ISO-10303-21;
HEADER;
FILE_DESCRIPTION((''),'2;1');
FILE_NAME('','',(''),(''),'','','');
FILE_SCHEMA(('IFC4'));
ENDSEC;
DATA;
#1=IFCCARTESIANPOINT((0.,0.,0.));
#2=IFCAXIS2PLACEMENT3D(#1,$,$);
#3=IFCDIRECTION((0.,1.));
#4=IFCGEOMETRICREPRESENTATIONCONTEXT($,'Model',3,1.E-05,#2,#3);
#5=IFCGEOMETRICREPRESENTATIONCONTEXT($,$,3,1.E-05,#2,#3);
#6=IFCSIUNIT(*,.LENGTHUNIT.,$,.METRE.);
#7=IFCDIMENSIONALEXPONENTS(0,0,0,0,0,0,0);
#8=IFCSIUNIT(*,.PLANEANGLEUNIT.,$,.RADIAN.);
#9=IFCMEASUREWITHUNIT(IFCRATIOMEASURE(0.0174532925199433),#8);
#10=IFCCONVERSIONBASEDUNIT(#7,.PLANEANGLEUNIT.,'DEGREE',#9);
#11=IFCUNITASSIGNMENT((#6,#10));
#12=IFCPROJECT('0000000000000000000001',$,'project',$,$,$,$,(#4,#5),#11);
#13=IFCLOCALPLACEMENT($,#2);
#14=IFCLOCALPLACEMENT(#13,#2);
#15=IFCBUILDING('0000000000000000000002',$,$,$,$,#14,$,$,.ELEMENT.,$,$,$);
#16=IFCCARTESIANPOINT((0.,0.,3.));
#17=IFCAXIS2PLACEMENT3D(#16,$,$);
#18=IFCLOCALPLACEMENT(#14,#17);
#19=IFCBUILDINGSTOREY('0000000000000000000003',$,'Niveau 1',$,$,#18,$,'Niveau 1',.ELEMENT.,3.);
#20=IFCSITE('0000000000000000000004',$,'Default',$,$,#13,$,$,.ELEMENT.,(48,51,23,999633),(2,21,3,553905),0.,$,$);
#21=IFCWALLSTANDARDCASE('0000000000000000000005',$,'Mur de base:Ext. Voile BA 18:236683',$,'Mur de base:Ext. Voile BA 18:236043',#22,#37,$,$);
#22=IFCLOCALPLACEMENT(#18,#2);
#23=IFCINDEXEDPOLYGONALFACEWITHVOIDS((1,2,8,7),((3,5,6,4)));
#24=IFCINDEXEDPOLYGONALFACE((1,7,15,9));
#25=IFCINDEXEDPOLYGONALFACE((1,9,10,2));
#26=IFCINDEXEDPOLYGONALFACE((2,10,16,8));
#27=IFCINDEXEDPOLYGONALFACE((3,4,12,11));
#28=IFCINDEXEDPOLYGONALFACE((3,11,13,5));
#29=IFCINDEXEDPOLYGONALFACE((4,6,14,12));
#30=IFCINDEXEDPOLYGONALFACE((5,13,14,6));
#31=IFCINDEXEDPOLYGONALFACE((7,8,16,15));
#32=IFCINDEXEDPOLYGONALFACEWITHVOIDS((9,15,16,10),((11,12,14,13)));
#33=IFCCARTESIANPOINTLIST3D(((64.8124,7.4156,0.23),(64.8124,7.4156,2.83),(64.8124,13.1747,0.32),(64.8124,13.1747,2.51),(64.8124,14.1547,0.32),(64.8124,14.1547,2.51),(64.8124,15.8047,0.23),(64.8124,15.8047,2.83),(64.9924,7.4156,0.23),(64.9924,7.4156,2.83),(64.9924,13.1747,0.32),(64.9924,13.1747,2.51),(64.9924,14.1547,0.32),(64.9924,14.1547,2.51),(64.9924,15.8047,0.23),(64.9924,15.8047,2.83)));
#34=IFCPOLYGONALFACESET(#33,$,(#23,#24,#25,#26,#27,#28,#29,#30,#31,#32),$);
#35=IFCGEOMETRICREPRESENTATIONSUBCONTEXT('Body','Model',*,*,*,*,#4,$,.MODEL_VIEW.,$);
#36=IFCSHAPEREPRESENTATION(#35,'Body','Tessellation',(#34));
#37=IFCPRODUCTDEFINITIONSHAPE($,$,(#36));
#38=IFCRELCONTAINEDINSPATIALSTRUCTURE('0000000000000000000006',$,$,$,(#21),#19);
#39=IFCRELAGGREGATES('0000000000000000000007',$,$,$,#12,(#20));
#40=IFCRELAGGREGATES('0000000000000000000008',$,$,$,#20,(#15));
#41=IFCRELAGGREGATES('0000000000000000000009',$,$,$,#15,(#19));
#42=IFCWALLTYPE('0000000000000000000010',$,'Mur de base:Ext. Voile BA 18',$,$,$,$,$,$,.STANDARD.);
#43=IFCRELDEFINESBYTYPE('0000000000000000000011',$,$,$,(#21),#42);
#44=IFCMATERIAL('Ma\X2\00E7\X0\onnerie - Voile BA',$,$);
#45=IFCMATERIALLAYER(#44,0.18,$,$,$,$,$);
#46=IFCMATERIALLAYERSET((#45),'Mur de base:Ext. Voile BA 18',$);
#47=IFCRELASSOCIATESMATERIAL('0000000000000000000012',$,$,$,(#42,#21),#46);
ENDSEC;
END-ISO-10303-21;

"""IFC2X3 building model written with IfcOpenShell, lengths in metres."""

from ifc_helpers import new_model, entity, si_unit, converted_unit, direction, frame, frame_2d, origin, place, context, subcontext, project, spatial, rectangle, extrude, material, layer, layer_set, layer_usage, type_object, element, save


model = new_model("IFC2X3")

# Units and contexts
model_context = context("Model", 3, precision=1e-05, world=origin(), true_north=direction((0.0, 1.0)))
context_of_model = context(None, 3, precision=1e-05, world=origin(), true_north=direction((0.0, 1.0)))
body_context = subcontext(model_context, "Body", "Model", "MODEL_VIEW")
ifc_project = project(units=[si_unit("LENGTHUNIT", "METRE"), converted_unit("PLANEANGLEUNIT", "DEGREE", entity("IfcRatioMeasure", 0.0174532925199433), si_unit("PLANEANGLEUNIT", "RADIAN"), dimensions=[0, 0, 0, 0, 0, 0, 0])], contexts=[model_context, context_of_model])

# Site, building, storey
site_placement = place(None, origin())
site = spatial("IfcSite", under=ifc_project, at=site_placement, Name="Default", CompositionType="ELEMENT", RefLatitude=(48, 51, 23, 999633), RefLongitude=(2, 21, 3, 553905), RefElevation=0.0)
building_placement = place(site_placement, origin())
building = spatial("IfcBuilding", under=site, at=building_placement, CompositionType="ELEMENT")
storey_placement = place(building_placement, frame((0.0, 0.0, 3.0)))
storey = spatial("IfcBuildingStorey", under=building, at=storey_placement, Name="Niveau 1", LongName="Niveau 1", CompositionType="ELEMENT", Elevation=3.0)

# Shared definitions
ifc_material = material(Name="Maçonnerie - Voile BA")

# Shared definitions
ifc_layer_1 = layer(ifc_material, 0.18)
ifc_layer_set_1 = layer_set([ifc_layer_1], Name="Mur de base:Ext. Voile BA 18")
wall_type_1 = type_object("IfcWallType", Name="Mur de base:Ext. Voile BA 18", PredefinedType="STANDARD", material=ifc_layer_set_1)

# Wall, opening
ifc_layer_usage_1 = layer_usage(ifc_layer_set_1, "AXIS2", "POSITIVE", -0.09)
wall_1_placement = place(storey_placement, frame((64.9024, 15.8047, 0.23), z_axis=(0.0, 0.0, 1.0), x_axis=(0.0, -1.0, 0.0)))
wall_1 = element("IfcWallStandardCase", 1, at=wall_1_placement, inside=storey, type_object=wall_type_1, material=ifc_layer_usage_1, Name="Mur de base:Ext. Voile BA 18:236683", ObjectType="Mur de base:Ext. Voile BA 18:236043", context=body_context, shape_type="SweptSolid", body=[
    extrude(rectangle(XDim=8.3891, YDim=0.18, at=frame_2d((4.1946, 0.0), x_axis=(-1.0, 0.0))), origin(), (0.0, 0.0, 1.0), 2.6),
])
opening_1_placement = place(wall_1_placement, origin())
element("IfcOpeningElement", 2, at=opening_1_placement, cuts=wall_1, ObjectType="Opening", context=body_context, shape_type="SweptSolid", body=[
    extrude(rectangle(XDim=2.19, YDim=0.98, at=frame_2d((0.0, 0.0), x_axis=(1.0, 0.0))), frame((2.14, -0.09, 1.185), z_axis=(0.0, 1.0, 0.0), x_axis=(0.0, 0.0, -1.0)), (0.0, 0.0, 1.0), 0.18),
])

save(model, "model.ifc")
